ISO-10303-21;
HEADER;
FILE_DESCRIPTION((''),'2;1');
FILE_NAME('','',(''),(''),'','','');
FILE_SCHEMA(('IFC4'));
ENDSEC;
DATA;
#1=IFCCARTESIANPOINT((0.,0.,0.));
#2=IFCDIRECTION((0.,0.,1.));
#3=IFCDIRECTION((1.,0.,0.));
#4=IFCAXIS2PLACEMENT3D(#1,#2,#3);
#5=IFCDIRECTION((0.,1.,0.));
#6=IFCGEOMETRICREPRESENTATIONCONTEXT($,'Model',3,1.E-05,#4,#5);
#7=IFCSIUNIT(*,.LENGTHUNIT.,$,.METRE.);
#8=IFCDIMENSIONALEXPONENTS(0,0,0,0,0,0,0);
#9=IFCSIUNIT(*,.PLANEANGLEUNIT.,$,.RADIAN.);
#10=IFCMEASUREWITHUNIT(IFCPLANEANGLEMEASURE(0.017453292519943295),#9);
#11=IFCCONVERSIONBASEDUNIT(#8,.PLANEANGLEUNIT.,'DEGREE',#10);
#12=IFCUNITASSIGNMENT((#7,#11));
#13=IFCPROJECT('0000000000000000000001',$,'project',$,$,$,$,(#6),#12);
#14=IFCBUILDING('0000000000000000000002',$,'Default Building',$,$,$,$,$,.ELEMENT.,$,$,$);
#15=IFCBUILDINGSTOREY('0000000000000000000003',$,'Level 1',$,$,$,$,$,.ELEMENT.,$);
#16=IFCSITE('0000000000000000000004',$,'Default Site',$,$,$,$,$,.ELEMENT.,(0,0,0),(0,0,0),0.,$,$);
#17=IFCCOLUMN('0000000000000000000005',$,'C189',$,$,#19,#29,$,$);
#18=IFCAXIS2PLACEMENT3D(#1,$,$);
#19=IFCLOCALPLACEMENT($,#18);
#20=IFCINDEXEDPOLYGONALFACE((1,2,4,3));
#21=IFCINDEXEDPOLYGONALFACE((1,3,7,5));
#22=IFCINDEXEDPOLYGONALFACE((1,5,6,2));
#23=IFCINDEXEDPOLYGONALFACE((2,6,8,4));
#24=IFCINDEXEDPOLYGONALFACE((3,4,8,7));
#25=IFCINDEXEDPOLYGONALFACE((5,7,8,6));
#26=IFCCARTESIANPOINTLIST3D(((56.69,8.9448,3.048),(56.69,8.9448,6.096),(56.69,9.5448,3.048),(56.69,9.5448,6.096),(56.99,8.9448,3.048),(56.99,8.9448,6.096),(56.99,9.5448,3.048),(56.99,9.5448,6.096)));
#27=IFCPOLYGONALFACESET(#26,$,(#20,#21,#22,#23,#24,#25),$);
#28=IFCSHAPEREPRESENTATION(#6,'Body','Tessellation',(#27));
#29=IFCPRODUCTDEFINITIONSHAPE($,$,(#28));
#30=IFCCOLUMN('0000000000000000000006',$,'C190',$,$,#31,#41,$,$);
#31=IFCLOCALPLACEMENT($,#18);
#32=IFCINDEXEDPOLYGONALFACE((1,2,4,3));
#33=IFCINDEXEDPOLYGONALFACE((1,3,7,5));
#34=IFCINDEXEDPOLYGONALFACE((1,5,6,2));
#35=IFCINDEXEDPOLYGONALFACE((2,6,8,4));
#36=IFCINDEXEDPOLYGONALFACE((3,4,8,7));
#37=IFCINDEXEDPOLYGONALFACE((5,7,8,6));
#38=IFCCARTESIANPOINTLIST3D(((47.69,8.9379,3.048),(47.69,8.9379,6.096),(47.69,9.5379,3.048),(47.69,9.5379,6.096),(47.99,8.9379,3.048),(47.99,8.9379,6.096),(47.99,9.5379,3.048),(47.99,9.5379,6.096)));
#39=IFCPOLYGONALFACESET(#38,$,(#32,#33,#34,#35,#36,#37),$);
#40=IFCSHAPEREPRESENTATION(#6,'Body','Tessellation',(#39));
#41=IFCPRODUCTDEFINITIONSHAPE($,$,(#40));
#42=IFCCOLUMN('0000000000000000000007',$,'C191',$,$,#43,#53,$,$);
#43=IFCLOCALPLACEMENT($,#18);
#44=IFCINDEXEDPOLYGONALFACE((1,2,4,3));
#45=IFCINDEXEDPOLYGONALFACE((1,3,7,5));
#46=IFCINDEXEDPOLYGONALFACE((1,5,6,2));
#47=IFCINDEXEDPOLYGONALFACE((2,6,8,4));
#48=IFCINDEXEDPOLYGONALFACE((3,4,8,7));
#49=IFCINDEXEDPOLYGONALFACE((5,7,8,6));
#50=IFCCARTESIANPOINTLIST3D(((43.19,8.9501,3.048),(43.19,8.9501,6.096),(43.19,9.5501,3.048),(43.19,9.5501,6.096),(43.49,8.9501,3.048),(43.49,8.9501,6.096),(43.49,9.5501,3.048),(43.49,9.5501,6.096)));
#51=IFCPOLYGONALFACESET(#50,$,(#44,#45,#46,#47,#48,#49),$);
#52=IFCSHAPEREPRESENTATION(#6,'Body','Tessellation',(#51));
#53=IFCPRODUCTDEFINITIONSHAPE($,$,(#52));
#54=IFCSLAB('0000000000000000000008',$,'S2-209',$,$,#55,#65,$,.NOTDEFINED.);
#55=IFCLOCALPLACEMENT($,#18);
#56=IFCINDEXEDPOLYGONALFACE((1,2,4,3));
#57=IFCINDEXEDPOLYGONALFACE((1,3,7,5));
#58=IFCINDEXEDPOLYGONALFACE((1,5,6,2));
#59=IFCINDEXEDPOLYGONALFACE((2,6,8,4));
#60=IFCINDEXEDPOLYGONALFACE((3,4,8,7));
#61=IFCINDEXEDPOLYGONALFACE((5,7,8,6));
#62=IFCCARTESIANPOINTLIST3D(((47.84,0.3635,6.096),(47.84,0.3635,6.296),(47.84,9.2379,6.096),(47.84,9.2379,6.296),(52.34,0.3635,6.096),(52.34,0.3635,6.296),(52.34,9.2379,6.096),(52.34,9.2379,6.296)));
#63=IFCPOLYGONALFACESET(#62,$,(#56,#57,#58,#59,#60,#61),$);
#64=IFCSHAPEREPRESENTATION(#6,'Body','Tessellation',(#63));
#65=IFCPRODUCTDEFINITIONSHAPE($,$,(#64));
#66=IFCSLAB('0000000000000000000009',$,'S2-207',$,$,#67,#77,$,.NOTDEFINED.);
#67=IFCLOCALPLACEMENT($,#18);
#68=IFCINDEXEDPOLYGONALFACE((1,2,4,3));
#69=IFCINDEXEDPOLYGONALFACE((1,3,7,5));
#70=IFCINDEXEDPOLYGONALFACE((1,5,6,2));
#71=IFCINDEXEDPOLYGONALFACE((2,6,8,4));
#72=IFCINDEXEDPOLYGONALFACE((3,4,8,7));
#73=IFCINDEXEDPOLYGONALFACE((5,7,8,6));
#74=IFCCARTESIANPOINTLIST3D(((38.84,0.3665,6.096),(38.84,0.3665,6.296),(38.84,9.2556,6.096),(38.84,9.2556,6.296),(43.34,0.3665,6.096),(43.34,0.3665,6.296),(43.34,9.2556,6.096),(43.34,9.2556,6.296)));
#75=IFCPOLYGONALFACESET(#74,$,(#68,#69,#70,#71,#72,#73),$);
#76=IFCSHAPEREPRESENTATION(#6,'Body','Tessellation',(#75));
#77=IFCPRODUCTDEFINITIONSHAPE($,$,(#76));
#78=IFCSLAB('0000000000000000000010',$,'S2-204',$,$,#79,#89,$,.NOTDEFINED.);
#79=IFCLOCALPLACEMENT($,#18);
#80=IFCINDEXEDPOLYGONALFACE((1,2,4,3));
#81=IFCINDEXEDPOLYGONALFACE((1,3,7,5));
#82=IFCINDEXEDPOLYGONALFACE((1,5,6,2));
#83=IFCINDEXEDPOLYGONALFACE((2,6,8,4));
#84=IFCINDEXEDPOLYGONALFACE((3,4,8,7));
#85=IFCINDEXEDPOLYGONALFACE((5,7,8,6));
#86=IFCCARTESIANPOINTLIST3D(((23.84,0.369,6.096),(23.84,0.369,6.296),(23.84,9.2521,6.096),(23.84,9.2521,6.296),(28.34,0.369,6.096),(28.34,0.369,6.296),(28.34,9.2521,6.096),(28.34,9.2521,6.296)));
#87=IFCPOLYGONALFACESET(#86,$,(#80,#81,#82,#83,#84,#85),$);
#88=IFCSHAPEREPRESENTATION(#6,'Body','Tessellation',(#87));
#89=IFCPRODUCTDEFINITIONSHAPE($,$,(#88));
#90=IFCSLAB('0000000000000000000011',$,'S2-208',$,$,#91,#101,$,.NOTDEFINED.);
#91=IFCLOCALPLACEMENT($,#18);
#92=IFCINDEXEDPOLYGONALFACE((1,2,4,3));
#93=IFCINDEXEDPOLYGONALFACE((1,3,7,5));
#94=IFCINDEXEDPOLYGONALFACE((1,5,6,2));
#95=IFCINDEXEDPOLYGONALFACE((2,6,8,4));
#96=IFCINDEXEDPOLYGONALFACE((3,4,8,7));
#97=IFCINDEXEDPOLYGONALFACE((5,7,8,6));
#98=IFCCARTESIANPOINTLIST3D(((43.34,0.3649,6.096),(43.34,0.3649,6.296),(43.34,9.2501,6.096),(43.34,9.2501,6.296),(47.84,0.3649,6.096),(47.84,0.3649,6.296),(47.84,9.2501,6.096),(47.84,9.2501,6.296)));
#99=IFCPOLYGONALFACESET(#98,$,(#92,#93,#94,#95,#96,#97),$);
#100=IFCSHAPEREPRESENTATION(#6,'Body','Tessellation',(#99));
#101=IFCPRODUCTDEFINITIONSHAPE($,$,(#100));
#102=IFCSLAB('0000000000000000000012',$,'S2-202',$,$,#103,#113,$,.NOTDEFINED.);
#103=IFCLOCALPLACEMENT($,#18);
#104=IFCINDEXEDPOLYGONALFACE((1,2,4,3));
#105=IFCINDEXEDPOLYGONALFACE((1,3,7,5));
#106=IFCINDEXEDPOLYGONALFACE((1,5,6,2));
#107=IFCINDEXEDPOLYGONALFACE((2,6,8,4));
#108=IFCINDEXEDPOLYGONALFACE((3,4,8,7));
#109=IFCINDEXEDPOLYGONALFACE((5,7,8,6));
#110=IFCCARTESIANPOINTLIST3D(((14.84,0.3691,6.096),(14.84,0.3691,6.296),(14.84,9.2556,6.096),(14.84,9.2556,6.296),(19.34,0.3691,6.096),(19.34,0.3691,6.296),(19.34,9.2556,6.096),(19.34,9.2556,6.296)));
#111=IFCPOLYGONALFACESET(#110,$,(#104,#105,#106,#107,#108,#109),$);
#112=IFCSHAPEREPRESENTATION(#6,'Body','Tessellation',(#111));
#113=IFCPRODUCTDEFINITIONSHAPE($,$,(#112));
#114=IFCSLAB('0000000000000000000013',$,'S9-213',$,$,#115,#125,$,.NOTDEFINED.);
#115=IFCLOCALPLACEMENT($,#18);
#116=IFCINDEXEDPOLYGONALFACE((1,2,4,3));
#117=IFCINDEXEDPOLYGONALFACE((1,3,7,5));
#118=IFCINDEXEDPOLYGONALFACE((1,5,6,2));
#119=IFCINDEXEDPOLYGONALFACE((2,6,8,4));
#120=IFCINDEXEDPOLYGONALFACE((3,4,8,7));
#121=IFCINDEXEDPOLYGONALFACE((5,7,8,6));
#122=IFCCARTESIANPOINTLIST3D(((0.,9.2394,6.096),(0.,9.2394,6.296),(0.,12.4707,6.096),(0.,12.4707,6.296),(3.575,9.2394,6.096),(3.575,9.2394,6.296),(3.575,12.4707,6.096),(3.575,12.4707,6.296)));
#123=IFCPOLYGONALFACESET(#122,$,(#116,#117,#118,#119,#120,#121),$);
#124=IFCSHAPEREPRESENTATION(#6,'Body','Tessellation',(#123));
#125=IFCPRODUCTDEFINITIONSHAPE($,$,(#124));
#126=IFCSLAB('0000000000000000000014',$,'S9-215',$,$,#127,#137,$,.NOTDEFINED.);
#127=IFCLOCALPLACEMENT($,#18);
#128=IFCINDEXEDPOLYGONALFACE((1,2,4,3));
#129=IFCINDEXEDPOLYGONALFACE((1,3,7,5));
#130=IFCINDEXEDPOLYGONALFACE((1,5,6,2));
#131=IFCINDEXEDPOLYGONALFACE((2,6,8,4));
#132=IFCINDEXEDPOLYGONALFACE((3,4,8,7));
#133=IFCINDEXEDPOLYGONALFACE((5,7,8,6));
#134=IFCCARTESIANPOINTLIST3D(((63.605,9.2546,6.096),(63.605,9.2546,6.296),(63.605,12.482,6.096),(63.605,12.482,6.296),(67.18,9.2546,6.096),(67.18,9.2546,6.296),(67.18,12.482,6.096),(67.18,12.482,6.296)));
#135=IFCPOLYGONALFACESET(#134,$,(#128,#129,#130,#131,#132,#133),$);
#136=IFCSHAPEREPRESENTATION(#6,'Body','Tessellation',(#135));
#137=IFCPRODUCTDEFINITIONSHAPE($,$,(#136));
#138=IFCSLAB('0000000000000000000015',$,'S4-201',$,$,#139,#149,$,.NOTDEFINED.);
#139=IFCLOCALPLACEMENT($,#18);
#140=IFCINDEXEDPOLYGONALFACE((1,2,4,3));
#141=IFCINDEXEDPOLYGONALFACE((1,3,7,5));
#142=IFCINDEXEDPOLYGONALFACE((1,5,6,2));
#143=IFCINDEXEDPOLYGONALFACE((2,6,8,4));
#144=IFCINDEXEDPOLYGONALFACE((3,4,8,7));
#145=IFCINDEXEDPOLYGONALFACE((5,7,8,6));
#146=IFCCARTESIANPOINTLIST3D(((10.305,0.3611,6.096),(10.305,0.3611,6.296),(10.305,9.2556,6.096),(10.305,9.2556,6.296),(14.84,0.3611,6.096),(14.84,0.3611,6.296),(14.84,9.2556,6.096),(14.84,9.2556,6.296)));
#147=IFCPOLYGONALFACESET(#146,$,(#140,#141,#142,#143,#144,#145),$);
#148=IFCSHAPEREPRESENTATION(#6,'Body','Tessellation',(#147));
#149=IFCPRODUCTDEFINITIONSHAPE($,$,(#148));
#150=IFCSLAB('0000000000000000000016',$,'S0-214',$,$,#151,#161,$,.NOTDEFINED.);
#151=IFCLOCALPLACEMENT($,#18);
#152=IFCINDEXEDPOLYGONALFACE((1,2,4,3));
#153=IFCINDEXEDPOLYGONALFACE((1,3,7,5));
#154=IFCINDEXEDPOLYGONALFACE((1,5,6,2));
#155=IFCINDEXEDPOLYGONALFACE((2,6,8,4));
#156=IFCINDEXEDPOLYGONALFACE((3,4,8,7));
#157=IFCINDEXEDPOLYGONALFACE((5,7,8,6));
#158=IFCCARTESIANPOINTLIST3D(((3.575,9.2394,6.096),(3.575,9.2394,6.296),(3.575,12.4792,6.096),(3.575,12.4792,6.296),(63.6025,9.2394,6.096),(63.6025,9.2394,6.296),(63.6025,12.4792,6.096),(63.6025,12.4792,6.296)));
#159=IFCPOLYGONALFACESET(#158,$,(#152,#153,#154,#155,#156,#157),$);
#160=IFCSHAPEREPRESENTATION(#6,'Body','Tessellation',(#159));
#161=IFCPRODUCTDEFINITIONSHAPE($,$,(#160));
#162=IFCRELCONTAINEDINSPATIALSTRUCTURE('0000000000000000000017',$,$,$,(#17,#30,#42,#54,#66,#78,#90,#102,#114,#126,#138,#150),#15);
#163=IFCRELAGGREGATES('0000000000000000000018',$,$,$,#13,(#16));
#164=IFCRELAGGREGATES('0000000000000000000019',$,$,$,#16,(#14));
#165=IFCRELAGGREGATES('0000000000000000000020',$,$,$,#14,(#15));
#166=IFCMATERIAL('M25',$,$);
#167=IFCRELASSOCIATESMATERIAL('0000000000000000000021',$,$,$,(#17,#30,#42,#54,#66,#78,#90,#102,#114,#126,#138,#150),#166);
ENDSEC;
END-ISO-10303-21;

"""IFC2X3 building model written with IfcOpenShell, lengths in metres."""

from ifc_helpers import new_model, entity, si_unit, converted_unit, direction, frame, frame_2d, origin_with_axes, place, context, project, spatial, rectangle, extrude, material, element, save


model = new_model("IFC2X3")

# Units and contexts
model_context = context("Model", 3, precision=1e-05, world=origin_with_axes(), true_north=direction((0.0, 1.0, 0.0)))
ifc_project = project(units=[si_unit("LENGTHUNIT", "METRE"), converted_unit("PLANEANGLEUNIT", "DEGREE", entity("IfcPlaneAngleMeasure", 0.017453292519943295), si_unit("PLANEANGLEUNIT", "RADIAN"), dimensions=[0, 0, 0, 0, 0, 0, 0])], contexts=[model_context])

# Site, building, storey
site = spatial("IfcSite", under=ifc_project, Name="Default Site", CompositionType="ELEMENT", RefLatitude=(0, 0, 0), RefLongitude=(0, 0, 0), RefElevation=0.0)
building = spatial("IfcBuilding", under=site, Name="Default Building", CompositionType="ELEMENT")
storey = spatial("IfcBuildingStorey", under=building, Name="Level 1", CompositionType="ELEMENT")

# Columns
ifc_material = material(Name="M25")
placement = place(None, origin_with_axes())
element("IfcColumn", 1, at=placement, inside=storey, material=ifc_material, Name="C189", context=model_context, shape_type="SweptSolid", body=[
    extrude(rectangle(XDim=0.3, YDim=0.6, at=frame_2d((0.0, 0.0), x_axis=(1.0, 0.0, 0.0))), frame((56.84, 9.2448, 3.048), z_axis=(0.0, 0.0, 1.0), x_axis=(1.0, 0.0, 0.0)), (0.0, 0.0, 1.0), 3.048),
])
element("IfcColumn", 2, at=placement, inside=storey, material=ifc_material, Name="C190", context=model_context, shape_type="SweptSolid", body=[
    extrude(rectangle(XDim=0.3, YDim=0.6, at=frame_2d((0.0, 0.0), x_axis=(1.0, 0.0, 0.0))), frame((47.84, 9.2379, 3.048), z_axis=(0.0, 0.0, 1.0), x_axis=(1.0, 0.0, 0.0)), (0.0, 0.0, 1.0), 3.048),
])
element("IfcColumn", 3, at=placement, inside=storey, material=ifc_material, Name="C191", context=model_context, shape_type="SweptSolid", body=[
    extrude(rectangle(XDim=0.3, YDim=0.6, at=frame_2d((0.0, 0.0), x_axis=(1.0, 0.0, 0.0))), frame((43.34, 9.2501, 3.048), z_axis=(0.0, 0.0, 1.0), x_axis=(1.0, 0.0, 0.0)), (0.0, 0.0, 1.0), 3.048),
])

# Slabs
element("IfcSlab", 4, at=placement, inside=storey, material=ifc_material, Name="S2-209", PredefinedType="NOTDEFINED", context=model_context, shape_type="SweptSolid", body=[
    extrude(rectangle(XDim=4.5, YDim=8.8744, at=frame_2d((0.0, 0.0), x_axis=(1.0, 0.0, 0.0))), frame((50.09, 4.8007, 6.096), z_axis=(0.0, 0.0, 1.0), x_axis=(1.0, 0.0, 0.0)), (0.0, 0.0, 1.0), 0.2),
])
element("IfcSlab", 5, at=placement, inside=storey, material=ifc_material, Name="S2-207", PredefinedType="NOTDEFINED", context=model_context, shape_type="SweptSolid", body=[
    extrude(rectangle(XDim=4.5, YDim=8.8891, at=frame_2d((0.0, 0.0), x_axis=(1.0, 0.0, 0.0))), frame((41.09, 4.811, 6.096), z_axis=(0.0, 0.0, 1.0), x_axis=(1.0, 0.0, 0.0)), (0.0, 0.0, 1.0), 0.2),
])
element("IfcSlab", 6, at=placement, inside=storey, material=ifc_material, Name="S2-204", PredefinedType="NOTDEFINED", context=model_context, shape_type="SweptSolid", body=[
    extrude(rectangle(XDim=4.5, YDim=8.8831, at=frame_2d((0.0, 0.0), x_axis=(1.0, 0.0, 0.0))), frame((26.09, 4.8106, 6.096), z_axis=(0.0, 0.0, 1.0), x_axis=(1.0, 0.0, 0.0)), (0.0, 0.0, 1.0), 0.2),
])
element("IfcSlab", 7, at=placement, inside=storey, material=ifc_material, Name="S2-208", PredefinedType="NOTDEFINED", context=model_context, shape_type="SweptSolid", body=[
    extrude(rectangle(XDim=4.5, YDim=8.8852, at=frame_2d((0.0, 0.0), x_axis=(1.0, 0.0, 0.0))), frame((45.59, 4.8075, 6.096), z_axis=(0.0, 0.0, 1.0), x_axis=(1.0, 0.0, 0.0)), (0.0, 0.0, 1.0), 0.2),
])
element("IfcSlab", 8, at=placement, inside=storey, material=ifc_material, Name="S2-202", PredefinedType="NOTDEFINED", context=model_context, shape_type="SweptSolid", body=[
    extrude(rectangle(XDim=4.5, YDim=8.8865, at=frame_2d((0.0, 0.0), x_axis=(1.0, 0.0, 0.0))), frame((17.09, 4.8123, 6.096), z_axis=(0.0, 0.0, 1.0), x_axis=(1.0, 0.0, 0.0)), (0.0, 0.0, 1.0), 0.2),
])
element("IfcSlab", 9, at=placement, inside=storey, material=ifc_material, Name="S9-213", PredefinedType="NOTDEFINED", context=model_context, shape_type="SweptSolid", body=[
    extrude(rectangle(XDim=3.575, YDim=3.2313, at=frame_2d((0.0, 0.0), x_axis=(1.0, 0.0, 0.0))), frame((1.7875, 10.8551, 6.096), z_axis=(0.0, 0.0, 1.0), x_axis=(1.0, 0.0, 0.0)), (0.0, 0.0, 1.0), 0.2),
])
element("IfcSlab", 10, at=placement, inside=storey, material=ifc_material, Name="S9-215", PredefinedType="NOTDEFINED", context=model_context, shape_type="SweptSolid", body=[
    extrude(rectangle(XDim=3.575, YDim=3.2274, at=frame_2d((0.0, 0.0), x_axis=(1.0, 0.0, 0.0))), frame((65.3925, 10.8683, 6.096), z_axis=(0.0, 0.0, 1.0), x_axis=(1.0, 0.0, 0.0)), (0.0, 0.0, 1.0), 0.2),
])
element("IfcSlab", 11, at=placement, inside=storey, material=ifc_material, Name="S4-201", PredefinedType="NOTDEFINED", context=model_context, shape_type="SweptSolid", body=[
    extrude(rectangle(XDim=4.535, YDim=8.8945, at=frame_2d((0.0, 0.0), x_axis=(1.0, 0.0, 0.0))), frame((12.5725, 4.8083, 6.096), z_axis=(0.0, 0.0, 1.0), x_axis=(1.0, 0.0, 0.0)), (0.0, 0.0, 1.0), 0.2),
])
element("IfcSlab", 12, at=placement, inside=storey, material=ifc_material, Name="S0-214", PredefinedType="NOTDEFINED", context=model_context, shape_type="SweptSolid", body=[
    extrude(rectangle(XDim=60.0275, YDim=3.2398, at=frame_2d((0.0, 0.0), x_axis=(1.0, 0.0, 0.0))), frame((33.5887, 10.8593, 6.096), z_axis=(0.0, 0.0, 1.0), x_axis=(1.0, 0.0, 0.0)), (0.0, 0.0, 1.0), 0.2),
])

save(model, "model.ifc")
